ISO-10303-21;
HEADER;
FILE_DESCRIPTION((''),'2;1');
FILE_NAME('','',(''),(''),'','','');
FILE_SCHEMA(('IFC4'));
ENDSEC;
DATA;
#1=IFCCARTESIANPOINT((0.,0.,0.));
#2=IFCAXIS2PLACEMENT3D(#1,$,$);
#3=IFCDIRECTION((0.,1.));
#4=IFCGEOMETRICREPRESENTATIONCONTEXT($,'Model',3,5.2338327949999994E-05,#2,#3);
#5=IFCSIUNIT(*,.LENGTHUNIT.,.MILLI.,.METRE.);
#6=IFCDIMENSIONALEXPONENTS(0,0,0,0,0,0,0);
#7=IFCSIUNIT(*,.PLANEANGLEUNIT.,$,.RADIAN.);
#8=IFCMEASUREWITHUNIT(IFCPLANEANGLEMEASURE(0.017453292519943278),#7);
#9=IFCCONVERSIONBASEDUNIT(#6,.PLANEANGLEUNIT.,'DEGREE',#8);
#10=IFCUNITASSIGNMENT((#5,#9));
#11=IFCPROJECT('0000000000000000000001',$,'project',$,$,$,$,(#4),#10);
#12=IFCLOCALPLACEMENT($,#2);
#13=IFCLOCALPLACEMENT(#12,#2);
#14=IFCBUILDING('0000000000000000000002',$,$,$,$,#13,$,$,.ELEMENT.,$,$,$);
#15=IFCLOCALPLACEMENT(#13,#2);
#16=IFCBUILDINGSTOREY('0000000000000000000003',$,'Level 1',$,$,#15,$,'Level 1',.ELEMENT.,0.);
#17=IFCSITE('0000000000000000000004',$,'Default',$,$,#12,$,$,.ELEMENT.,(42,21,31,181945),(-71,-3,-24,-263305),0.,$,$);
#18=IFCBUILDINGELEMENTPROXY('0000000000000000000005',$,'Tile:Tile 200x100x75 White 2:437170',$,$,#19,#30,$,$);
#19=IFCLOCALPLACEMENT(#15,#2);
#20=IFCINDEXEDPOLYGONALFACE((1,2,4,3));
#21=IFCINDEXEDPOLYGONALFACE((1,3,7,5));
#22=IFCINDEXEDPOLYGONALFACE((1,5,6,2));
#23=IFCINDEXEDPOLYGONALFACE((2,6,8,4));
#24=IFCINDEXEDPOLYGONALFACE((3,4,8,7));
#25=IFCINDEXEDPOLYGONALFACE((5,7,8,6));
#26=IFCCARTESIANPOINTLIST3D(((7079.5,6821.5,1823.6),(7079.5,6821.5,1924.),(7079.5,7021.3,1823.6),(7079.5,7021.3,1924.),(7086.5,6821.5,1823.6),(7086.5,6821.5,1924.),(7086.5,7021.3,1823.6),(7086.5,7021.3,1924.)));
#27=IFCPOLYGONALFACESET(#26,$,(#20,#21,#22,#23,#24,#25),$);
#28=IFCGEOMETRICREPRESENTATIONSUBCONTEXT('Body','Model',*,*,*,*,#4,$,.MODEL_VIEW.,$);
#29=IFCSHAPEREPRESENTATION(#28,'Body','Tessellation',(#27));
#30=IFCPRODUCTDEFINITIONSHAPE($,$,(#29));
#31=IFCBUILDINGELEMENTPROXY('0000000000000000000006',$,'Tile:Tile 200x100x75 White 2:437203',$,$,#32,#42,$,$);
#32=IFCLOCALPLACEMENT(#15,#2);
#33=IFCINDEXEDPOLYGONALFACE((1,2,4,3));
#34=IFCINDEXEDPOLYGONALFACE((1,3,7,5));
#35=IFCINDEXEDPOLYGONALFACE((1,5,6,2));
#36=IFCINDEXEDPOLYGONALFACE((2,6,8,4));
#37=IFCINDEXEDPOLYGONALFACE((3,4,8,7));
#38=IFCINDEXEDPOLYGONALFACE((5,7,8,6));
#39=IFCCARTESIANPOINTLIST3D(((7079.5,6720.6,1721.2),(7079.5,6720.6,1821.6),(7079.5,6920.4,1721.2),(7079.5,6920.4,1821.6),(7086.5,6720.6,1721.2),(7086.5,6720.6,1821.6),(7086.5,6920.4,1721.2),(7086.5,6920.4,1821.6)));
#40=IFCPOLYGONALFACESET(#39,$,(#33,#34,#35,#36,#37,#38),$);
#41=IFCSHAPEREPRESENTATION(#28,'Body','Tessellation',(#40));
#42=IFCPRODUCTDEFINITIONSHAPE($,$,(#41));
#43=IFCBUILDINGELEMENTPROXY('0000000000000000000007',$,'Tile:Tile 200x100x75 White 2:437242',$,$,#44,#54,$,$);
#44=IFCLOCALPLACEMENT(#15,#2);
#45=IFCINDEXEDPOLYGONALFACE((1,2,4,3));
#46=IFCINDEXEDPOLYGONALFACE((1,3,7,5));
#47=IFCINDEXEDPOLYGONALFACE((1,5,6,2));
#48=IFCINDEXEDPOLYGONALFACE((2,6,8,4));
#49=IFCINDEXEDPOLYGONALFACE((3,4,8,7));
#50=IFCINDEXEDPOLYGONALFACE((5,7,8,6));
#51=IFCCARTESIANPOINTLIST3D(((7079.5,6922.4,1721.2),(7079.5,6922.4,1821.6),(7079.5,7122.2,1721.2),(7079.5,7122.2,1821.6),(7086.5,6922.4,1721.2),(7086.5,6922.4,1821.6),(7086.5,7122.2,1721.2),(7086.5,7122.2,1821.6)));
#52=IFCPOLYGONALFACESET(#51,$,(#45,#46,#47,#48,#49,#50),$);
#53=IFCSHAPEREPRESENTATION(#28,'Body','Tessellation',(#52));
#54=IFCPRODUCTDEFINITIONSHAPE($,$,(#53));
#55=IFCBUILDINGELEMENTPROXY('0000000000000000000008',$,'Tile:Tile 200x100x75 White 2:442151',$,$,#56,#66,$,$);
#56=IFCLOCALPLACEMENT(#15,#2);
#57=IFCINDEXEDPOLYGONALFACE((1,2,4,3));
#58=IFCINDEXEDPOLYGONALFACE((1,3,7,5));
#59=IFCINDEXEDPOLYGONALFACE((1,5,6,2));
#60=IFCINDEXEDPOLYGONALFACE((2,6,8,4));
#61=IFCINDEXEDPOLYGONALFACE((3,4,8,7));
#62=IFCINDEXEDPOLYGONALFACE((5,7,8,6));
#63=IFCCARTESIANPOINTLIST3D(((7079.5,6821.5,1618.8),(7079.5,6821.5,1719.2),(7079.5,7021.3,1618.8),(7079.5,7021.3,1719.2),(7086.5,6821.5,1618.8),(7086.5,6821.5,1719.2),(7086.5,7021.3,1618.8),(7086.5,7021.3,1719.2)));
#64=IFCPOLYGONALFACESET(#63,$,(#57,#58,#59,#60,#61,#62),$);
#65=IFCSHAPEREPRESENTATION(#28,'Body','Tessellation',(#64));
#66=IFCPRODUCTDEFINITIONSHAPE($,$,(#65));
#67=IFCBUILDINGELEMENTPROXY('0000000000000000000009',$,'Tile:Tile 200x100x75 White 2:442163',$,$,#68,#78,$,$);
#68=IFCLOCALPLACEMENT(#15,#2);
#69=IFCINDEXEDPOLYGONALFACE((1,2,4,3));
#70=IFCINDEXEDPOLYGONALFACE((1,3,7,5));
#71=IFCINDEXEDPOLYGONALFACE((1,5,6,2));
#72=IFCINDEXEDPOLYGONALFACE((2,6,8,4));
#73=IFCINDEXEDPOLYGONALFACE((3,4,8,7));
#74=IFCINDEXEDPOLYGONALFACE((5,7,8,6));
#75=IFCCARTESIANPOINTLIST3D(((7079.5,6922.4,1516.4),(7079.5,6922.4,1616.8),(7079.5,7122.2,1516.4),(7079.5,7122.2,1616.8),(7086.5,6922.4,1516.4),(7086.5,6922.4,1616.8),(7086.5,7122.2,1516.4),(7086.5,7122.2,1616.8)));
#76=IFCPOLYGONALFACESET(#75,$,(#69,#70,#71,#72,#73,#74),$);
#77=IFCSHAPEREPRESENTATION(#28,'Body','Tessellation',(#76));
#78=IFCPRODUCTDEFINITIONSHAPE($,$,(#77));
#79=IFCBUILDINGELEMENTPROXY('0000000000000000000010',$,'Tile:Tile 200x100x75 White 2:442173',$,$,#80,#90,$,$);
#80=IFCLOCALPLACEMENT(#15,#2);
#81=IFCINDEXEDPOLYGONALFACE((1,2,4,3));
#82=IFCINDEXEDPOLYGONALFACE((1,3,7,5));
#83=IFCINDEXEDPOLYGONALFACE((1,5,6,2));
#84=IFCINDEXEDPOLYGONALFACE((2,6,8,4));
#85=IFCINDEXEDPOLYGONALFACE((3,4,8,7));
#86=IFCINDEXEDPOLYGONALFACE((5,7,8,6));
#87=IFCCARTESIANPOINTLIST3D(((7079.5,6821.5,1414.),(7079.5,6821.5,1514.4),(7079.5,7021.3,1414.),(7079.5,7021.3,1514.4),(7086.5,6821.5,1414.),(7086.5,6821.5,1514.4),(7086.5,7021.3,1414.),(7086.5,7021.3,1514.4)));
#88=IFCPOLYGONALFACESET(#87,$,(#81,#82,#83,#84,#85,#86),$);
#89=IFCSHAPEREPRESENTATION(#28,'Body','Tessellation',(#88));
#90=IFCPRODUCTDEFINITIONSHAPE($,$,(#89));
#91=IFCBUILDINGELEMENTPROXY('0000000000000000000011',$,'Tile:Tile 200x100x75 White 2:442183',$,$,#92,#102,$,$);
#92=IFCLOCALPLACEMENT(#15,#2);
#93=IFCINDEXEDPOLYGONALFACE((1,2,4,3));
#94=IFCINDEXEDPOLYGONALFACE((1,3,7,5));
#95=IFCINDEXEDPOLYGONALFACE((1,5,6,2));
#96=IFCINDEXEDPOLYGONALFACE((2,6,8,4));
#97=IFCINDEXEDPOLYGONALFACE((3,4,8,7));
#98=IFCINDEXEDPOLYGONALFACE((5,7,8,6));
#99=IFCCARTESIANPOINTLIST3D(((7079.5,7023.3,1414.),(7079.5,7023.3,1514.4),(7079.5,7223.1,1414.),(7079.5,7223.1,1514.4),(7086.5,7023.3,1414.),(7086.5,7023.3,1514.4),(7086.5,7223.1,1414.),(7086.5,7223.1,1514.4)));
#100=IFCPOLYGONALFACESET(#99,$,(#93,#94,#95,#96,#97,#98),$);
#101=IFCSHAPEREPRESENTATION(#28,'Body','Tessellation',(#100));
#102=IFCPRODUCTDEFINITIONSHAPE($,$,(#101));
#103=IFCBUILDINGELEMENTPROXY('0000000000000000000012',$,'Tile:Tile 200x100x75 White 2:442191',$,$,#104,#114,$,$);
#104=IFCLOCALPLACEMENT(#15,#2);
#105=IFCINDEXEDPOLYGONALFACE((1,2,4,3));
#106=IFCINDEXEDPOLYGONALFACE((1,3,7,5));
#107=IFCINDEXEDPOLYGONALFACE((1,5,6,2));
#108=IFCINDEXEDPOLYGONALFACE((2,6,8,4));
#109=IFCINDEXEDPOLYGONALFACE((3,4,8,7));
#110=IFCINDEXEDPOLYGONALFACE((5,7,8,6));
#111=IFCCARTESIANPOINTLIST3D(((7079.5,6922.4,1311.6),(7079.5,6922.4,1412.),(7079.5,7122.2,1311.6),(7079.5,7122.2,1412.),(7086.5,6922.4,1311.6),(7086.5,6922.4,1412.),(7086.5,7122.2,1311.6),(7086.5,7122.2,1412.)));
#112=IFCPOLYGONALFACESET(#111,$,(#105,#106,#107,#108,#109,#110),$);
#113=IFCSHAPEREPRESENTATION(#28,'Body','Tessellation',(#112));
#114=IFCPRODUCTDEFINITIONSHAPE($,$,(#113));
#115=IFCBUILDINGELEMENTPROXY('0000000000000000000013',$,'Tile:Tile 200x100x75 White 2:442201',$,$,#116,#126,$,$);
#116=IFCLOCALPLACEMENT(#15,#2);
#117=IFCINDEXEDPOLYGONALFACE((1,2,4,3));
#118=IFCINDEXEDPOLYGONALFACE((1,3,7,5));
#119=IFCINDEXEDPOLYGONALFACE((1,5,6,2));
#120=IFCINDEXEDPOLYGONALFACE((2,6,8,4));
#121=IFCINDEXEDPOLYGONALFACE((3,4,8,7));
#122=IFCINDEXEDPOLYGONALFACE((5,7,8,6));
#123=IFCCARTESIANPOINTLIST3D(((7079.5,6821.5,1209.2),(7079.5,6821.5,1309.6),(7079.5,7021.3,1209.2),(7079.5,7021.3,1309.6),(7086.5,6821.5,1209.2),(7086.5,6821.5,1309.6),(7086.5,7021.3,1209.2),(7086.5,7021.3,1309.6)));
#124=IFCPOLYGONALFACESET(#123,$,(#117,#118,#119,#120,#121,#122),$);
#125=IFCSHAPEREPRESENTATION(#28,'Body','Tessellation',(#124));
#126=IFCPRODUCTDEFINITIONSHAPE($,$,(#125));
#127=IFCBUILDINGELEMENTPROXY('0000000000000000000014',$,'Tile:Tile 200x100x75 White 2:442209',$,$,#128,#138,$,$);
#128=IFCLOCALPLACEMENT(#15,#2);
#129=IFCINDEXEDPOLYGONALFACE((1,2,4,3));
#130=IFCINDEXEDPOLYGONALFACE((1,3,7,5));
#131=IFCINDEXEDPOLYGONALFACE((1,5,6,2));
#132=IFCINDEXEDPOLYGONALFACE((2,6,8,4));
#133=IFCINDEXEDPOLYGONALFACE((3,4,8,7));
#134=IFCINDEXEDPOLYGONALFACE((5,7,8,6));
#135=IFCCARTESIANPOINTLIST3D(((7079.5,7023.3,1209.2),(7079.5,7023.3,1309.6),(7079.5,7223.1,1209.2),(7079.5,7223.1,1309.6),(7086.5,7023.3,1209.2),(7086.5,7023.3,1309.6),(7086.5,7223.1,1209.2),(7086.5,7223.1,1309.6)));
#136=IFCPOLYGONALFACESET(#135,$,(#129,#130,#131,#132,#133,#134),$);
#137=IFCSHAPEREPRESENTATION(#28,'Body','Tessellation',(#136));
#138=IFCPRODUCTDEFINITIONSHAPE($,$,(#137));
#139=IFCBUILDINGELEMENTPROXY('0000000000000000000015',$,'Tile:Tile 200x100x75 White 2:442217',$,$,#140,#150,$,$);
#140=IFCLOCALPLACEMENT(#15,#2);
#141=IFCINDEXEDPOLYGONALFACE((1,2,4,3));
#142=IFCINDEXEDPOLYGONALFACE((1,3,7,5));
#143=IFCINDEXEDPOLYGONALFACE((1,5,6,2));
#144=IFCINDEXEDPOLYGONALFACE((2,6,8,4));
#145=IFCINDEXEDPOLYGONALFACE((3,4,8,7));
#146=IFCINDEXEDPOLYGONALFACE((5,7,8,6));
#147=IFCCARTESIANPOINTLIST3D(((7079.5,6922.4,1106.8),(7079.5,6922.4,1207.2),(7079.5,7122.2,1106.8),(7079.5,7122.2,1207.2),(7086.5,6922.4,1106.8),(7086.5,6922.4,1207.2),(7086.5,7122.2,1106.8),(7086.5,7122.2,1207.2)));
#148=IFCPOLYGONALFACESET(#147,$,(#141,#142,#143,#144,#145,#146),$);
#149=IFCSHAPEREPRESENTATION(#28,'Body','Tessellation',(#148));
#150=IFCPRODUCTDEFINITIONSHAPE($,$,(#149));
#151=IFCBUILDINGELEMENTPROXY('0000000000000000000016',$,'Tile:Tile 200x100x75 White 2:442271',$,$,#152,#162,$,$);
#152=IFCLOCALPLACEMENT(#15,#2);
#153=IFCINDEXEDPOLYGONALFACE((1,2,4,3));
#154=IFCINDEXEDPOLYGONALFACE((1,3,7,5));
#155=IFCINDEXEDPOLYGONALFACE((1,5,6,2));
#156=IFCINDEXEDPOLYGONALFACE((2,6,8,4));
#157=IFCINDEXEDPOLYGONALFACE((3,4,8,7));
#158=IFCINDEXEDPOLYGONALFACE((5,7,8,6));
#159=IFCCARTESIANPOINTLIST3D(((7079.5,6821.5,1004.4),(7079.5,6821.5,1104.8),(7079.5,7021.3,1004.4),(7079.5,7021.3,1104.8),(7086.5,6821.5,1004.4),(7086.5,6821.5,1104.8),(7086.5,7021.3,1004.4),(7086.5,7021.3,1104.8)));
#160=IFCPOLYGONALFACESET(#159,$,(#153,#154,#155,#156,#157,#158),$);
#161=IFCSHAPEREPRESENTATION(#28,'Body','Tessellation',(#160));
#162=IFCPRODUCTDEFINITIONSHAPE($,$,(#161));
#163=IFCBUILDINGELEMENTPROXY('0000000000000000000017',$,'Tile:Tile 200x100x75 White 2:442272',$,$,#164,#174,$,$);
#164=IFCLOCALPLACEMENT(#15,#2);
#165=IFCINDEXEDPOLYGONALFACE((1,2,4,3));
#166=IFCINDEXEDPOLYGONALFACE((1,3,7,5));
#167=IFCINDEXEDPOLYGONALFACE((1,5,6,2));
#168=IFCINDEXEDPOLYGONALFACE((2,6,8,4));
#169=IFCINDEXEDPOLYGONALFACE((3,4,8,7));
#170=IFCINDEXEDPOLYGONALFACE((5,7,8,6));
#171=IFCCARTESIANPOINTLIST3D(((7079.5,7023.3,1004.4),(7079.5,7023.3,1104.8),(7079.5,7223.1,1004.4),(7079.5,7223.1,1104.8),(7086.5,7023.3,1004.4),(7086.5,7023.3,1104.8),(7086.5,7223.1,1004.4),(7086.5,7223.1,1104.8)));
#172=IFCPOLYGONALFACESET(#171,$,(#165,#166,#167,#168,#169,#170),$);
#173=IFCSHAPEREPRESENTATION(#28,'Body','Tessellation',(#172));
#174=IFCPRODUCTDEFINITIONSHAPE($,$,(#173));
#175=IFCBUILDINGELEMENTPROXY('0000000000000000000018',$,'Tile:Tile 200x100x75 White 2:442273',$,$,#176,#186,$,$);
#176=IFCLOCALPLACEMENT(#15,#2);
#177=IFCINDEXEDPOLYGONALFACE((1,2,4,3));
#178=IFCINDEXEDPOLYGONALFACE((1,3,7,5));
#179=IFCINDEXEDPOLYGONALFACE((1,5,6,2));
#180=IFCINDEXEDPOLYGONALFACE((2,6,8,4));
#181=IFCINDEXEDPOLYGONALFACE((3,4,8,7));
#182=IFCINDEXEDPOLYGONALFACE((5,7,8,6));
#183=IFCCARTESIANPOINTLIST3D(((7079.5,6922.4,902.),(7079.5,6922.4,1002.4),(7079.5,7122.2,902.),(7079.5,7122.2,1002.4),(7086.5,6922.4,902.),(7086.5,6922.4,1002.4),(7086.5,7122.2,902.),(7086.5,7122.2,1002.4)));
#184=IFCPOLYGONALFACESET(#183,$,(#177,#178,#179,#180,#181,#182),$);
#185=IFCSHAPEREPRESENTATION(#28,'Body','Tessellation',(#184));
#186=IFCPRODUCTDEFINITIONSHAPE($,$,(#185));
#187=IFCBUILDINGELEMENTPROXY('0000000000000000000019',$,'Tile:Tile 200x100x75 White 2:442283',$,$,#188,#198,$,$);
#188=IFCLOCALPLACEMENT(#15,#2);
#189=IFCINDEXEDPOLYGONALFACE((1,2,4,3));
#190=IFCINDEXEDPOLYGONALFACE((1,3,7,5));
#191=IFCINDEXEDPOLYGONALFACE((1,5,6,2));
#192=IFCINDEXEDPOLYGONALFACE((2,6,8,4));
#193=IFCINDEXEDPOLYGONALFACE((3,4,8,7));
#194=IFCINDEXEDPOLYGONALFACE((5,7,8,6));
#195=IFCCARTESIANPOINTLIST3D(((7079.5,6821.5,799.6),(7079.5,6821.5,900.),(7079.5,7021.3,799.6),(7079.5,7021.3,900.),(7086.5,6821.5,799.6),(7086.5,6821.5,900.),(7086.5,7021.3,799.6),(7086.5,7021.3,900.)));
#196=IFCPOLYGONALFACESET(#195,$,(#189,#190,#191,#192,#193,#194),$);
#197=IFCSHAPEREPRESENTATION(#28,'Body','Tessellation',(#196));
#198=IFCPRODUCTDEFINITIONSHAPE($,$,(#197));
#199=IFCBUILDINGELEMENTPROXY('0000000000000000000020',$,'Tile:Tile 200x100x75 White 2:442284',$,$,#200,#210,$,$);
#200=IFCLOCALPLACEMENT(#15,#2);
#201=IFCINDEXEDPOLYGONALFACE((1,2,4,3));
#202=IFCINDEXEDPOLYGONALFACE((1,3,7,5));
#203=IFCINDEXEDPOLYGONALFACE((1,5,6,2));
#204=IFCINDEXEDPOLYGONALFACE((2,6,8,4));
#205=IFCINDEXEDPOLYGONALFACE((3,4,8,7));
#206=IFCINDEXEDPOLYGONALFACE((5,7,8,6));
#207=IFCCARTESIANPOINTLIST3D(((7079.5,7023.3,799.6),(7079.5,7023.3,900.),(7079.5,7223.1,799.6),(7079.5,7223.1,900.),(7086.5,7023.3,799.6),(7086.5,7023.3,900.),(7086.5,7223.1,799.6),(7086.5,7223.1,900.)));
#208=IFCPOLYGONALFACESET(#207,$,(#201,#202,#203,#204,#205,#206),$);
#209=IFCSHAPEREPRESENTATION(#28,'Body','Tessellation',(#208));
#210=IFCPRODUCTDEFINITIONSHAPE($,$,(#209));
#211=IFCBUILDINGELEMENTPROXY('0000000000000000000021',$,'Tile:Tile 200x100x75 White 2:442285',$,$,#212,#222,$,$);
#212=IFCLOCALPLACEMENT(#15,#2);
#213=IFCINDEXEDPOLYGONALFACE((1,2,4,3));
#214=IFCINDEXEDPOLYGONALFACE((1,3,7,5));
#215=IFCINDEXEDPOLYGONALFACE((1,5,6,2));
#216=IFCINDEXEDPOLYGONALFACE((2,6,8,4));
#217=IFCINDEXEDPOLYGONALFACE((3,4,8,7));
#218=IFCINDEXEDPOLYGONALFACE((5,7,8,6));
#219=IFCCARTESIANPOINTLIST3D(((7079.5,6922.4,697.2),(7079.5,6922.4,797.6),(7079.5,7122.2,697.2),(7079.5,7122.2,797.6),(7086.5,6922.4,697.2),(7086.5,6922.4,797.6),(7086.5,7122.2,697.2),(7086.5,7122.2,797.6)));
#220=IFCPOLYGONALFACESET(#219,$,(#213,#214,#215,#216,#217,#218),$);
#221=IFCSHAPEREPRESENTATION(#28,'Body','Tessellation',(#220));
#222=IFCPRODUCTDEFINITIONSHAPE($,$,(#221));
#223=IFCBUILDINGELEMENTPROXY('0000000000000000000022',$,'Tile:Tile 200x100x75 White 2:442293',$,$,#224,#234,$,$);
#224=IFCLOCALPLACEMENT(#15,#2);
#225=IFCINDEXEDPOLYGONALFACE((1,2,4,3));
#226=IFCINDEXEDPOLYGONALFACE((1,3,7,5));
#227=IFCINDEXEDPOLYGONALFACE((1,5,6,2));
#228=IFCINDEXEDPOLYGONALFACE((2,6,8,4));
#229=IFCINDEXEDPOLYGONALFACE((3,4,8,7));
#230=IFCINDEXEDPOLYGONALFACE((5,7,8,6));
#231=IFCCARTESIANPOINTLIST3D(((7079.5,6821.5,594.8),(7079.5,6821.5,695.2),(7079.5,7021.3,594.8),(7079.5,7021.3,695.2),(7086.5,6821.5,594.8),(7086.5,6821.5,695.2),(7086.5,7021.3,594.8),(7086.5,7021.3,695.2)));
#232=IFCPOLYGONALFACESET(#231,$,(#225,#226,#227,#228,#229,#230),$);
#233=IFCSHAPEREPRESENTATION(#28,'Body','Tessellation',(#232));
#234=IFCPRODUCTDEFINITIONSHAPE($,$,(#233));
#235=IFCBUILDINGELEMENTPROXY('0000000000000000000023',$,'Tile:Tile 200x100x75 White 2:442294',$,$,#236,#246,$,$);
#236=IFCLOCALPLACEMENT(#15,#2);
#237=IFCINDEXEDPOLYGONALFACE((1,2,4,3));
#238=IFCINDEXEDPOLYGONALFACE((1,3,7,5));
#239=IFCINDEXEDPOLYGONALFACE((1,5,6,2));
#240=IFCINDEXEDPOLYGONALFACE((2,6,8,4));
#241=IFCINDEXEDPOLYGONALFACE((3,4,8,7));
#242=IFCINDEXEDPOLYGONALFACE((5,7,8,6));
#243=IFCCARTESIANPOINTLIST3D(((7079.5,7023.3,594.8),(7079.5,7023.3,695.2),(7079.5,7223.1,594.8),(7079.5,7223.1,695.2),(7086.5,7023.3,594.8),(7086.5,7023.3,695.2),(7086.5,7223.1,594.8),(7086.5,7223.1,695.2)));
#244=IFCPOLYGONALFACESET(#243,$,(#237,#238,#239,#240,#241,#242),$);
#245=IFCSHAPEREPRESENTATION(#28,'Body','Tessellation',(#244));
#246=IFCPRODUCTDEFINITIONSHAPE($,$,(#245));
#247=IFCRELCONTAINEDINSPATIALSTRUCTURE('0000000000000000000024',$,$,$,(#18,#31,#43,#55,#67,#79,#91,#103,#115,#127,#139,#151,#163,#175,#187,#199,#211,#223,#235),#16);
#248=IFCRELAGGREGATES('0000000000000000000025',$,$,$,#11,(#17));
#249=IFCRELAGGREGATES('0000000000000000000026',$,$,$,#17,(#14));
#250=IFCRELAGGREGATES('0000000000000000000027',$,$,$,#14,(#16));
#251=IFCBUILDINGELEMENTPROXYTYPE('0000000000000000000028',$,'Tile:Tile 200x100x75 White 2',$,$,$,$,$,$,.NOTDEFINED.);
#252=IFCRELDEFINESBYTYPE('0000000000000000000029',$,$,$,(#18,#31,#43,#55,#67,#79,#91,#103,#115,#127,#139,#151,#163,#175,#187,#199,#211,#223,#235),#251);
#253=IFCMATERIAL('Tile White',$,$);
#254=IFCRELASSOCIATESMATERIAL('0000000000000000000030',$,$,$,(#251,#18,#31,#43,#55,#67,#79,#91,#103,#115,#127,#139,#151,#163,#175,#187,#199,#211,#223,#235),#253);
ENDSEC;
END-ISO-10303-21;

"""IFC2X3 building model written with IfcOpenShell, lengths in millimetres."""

from ifc_helpers import new_model, entity, si_unit, converted_unit, direction, frame, frame_2d, origin, place, context, subcontext, project, spatial, rectangle, extrude, source, transform, mapped, material, type_object, type_shapes, element, save


model = new_model("IFC2X3")

# Units and contexts
model_context = context("Model", 3, precision=5.2338327949999994e-05, world=origin(), true_north=direction((0.0, 1.0)))
body_context = subcontext(model_context, "Body", "Model", "MODEL_VIEW")
ifc_project = project(units=[si_unit("LENGTHUNIT", "METRE", prefix="MILLI"), converted_unit("PLANEANGLEUNIT", "DEGREE", entity("IfcPlaneAngleMeasure", 0.017453292519943278), si_unit("PLANEANGLEUNIT", "RADIAN"), dimensions=[0, 0, 0, 0, 0, 0, 0])], contexts=[model_context])

# Site, building, storey
site_placement = place(None, origin())
site = spatial("IfcSite", under=ifc_project, at=site_placement, Name="Default", CompositionType="ELEMENT", RefLatitude=(42, 21, 31, 181945), RefLongitude=(-71, -3, -24, -263305), RefElevation=0.0)
building_placement = place(site_placement, origin())
building = spatial("IfcBuilding", under=site, at=building_placement, CompositionType="ELEMENT")
storey_placement = place(building_placement, origin())
storey = spatial("IfcBuildingStorey", under=building, at=storey_placement, Name="Level 1", LongName="Level 1", CompositionType="ELEMENT", Elevation=0.0)

# Building element proxies
ifc_material_1 = material(Name="Tile White")
building_element_proxy_type_1 = type_object("IfcBuildingElementProxyType", Name="Tile:Tile 200x100x75 White 2", PredefinedType="NOTDEFINED", material=ifc_material_1)
shared_shape_1 = source(origin(), body_context, "Body", "SweptSolid", [
    extrude(rectangle(XDim=199.8, YDim=100.4, at=frame_2d((0.0, 0.0), x_axis=(1.0, 0.0))), frame((-50.2, -99.9, 0.0), z_axis=(0.0, 0.0, 1.0), x_axis=(0.0, -1.0, 0.0)), (0.0, 0.0, 1.0), 7.0),
])
type_shapes(building_element_proxy_type_1, [shared_shape_1])
for number, where, z_axis, x_axis, name in (
    (1, (7086.5, 7021.3, 1924.0), (-1.0, 0.0, 0.0), (0.0, 0.0, 1.0), "Tile:Tile 200x100x75 White 2:437170"),
    (2, (7086.5, 6920.4, 1821.6), (-1.0, 0.0, 0.0), (0.0, 0.0, 1.0), "Tile:Tile 200x100x75 White 2:437203"),
    (3, (7086.5, 7122.2, 1821.6), (-1.0, 0.0, 0.0), (0.0, 0.0, 1.0), "Tile:Tile 200x100x75 White 2:437242"),
    (4, (7086.5, 7021.3, 1719.2), (-1.0, 0.0, 0.0), (0.0, 0.0, 1.0), "Tile:Tile 200x100x75 White 2:442151"),
    (5, (7086.5, 7122.2, 1616.8), (-1.0, 0.0, 0.0), (0.0, 0.0, 1.0), "Tile:Tile 200x100x75 White 2:442163"),
    (6, (7086.5, 7021.3, 1514.4), (-1.0, 0.0, 0.0), (0.0, 0.0, 1.0), "Tile:Tile 200x100x75 White 2:442173"),
    (7, (7086.5, 7223.1, 1514.4), (-1.0, 0.0, 0.0), (0.0, 0.0, 1.0), "Tile:Tile 200x100x75 White 2:442183"),
    (8, (7086.5, 7122.2, 1412.0), (-1.0, 0.0, 0.0), (0.0, 0.0, 1.0), "Tile:Tile 200x100x75 White 2:442191"),
    (9, (7086.5, 7021.3, 1309.6), (-1.0, 0.0, 0.0), (0.0, 0.0, 1.0), "Tile:Tile 200x100x75 White 2:442201"),
    (10, (7086.5, 7223.1, 1309.6), (-1.0, 0.0, 0.0), (0.0, 0.0, 1.0), "Tile:Tile 200x100x75 White 2:442209"),
    (11, (7086.5, 7122.2, 1207.2), (-1.0, 0.0, 0.0), (0.0, 0.0, 1.0), "Tile:Tile 200x100x75 White 2:442217"),
    (12, (7086.5, 7021.3, 1104.8), (-1.0, 0.0, 0.0), (0.0, 0.0, 1.0), "Tile:Tile 200x100x75 White 2:442271"),
    (13, (7086.5, 7223.1, 1104.8), (-1.0, 0.0, 0.0), (0.0, 0.0, 1.0), "Tile:Tile 200x100x75 White 2:442272"),
    (14, (7086.5, 7122.2, 1002.4), (-1.0, 0.0, 0.0), (0.0, 0.0, 1.0), "Tile:Tile 200x100x75 White 2:442273"),
    (15, (7086.5, 7021.3, 900.0), (-1.0, 0.0, 0.0), (0.0, 0.0, 1.0), "Tile:Tile 200x100x75 White 2:442283"),
    (16, (7086.5, 7223.1, 900.0), (-1.0, 0.0, 0.0), (0.0, 0.0, 1.0), "Tile:Tile 200x100x75 White 2:442284"),
    (17, (7086.5, 7122.2, 797.6), (-1.0, 0.0, 0.0), (0.0, 0.0, 1.0), "Tile:Tile 200x100x75 White 2:442285"),
    (18, (7086.5, 7021.3, 695.2), (-1.0, 0.0, 0.0), (0.0, 0.0, 1.0), "Tile:Tile 200x100x75 White 2:442293"),
    (19, (7086.5, 7223.1, 695.2), (-1.0, 0.0, 0.0), (0.0, 0.0, 1.0), "Tile:Tile 200x100x75 White 2:442294"),
):
    element("IfcBuildingElementProxy", number, at=place(storey_placement, frame(where, z_axis=z_axis, x_axis=x_axis)), inside=storey, type_object=building_element_proxy_type_1, material=ifc_material_1, Name=name, context=body_context, shape_type="MappedRepresentation", body=[
        mapped(shared_shape_1, transform((0.0, 0.0, 0.0), scale=1.0)),
    ])

save(model, "model.ifc")
